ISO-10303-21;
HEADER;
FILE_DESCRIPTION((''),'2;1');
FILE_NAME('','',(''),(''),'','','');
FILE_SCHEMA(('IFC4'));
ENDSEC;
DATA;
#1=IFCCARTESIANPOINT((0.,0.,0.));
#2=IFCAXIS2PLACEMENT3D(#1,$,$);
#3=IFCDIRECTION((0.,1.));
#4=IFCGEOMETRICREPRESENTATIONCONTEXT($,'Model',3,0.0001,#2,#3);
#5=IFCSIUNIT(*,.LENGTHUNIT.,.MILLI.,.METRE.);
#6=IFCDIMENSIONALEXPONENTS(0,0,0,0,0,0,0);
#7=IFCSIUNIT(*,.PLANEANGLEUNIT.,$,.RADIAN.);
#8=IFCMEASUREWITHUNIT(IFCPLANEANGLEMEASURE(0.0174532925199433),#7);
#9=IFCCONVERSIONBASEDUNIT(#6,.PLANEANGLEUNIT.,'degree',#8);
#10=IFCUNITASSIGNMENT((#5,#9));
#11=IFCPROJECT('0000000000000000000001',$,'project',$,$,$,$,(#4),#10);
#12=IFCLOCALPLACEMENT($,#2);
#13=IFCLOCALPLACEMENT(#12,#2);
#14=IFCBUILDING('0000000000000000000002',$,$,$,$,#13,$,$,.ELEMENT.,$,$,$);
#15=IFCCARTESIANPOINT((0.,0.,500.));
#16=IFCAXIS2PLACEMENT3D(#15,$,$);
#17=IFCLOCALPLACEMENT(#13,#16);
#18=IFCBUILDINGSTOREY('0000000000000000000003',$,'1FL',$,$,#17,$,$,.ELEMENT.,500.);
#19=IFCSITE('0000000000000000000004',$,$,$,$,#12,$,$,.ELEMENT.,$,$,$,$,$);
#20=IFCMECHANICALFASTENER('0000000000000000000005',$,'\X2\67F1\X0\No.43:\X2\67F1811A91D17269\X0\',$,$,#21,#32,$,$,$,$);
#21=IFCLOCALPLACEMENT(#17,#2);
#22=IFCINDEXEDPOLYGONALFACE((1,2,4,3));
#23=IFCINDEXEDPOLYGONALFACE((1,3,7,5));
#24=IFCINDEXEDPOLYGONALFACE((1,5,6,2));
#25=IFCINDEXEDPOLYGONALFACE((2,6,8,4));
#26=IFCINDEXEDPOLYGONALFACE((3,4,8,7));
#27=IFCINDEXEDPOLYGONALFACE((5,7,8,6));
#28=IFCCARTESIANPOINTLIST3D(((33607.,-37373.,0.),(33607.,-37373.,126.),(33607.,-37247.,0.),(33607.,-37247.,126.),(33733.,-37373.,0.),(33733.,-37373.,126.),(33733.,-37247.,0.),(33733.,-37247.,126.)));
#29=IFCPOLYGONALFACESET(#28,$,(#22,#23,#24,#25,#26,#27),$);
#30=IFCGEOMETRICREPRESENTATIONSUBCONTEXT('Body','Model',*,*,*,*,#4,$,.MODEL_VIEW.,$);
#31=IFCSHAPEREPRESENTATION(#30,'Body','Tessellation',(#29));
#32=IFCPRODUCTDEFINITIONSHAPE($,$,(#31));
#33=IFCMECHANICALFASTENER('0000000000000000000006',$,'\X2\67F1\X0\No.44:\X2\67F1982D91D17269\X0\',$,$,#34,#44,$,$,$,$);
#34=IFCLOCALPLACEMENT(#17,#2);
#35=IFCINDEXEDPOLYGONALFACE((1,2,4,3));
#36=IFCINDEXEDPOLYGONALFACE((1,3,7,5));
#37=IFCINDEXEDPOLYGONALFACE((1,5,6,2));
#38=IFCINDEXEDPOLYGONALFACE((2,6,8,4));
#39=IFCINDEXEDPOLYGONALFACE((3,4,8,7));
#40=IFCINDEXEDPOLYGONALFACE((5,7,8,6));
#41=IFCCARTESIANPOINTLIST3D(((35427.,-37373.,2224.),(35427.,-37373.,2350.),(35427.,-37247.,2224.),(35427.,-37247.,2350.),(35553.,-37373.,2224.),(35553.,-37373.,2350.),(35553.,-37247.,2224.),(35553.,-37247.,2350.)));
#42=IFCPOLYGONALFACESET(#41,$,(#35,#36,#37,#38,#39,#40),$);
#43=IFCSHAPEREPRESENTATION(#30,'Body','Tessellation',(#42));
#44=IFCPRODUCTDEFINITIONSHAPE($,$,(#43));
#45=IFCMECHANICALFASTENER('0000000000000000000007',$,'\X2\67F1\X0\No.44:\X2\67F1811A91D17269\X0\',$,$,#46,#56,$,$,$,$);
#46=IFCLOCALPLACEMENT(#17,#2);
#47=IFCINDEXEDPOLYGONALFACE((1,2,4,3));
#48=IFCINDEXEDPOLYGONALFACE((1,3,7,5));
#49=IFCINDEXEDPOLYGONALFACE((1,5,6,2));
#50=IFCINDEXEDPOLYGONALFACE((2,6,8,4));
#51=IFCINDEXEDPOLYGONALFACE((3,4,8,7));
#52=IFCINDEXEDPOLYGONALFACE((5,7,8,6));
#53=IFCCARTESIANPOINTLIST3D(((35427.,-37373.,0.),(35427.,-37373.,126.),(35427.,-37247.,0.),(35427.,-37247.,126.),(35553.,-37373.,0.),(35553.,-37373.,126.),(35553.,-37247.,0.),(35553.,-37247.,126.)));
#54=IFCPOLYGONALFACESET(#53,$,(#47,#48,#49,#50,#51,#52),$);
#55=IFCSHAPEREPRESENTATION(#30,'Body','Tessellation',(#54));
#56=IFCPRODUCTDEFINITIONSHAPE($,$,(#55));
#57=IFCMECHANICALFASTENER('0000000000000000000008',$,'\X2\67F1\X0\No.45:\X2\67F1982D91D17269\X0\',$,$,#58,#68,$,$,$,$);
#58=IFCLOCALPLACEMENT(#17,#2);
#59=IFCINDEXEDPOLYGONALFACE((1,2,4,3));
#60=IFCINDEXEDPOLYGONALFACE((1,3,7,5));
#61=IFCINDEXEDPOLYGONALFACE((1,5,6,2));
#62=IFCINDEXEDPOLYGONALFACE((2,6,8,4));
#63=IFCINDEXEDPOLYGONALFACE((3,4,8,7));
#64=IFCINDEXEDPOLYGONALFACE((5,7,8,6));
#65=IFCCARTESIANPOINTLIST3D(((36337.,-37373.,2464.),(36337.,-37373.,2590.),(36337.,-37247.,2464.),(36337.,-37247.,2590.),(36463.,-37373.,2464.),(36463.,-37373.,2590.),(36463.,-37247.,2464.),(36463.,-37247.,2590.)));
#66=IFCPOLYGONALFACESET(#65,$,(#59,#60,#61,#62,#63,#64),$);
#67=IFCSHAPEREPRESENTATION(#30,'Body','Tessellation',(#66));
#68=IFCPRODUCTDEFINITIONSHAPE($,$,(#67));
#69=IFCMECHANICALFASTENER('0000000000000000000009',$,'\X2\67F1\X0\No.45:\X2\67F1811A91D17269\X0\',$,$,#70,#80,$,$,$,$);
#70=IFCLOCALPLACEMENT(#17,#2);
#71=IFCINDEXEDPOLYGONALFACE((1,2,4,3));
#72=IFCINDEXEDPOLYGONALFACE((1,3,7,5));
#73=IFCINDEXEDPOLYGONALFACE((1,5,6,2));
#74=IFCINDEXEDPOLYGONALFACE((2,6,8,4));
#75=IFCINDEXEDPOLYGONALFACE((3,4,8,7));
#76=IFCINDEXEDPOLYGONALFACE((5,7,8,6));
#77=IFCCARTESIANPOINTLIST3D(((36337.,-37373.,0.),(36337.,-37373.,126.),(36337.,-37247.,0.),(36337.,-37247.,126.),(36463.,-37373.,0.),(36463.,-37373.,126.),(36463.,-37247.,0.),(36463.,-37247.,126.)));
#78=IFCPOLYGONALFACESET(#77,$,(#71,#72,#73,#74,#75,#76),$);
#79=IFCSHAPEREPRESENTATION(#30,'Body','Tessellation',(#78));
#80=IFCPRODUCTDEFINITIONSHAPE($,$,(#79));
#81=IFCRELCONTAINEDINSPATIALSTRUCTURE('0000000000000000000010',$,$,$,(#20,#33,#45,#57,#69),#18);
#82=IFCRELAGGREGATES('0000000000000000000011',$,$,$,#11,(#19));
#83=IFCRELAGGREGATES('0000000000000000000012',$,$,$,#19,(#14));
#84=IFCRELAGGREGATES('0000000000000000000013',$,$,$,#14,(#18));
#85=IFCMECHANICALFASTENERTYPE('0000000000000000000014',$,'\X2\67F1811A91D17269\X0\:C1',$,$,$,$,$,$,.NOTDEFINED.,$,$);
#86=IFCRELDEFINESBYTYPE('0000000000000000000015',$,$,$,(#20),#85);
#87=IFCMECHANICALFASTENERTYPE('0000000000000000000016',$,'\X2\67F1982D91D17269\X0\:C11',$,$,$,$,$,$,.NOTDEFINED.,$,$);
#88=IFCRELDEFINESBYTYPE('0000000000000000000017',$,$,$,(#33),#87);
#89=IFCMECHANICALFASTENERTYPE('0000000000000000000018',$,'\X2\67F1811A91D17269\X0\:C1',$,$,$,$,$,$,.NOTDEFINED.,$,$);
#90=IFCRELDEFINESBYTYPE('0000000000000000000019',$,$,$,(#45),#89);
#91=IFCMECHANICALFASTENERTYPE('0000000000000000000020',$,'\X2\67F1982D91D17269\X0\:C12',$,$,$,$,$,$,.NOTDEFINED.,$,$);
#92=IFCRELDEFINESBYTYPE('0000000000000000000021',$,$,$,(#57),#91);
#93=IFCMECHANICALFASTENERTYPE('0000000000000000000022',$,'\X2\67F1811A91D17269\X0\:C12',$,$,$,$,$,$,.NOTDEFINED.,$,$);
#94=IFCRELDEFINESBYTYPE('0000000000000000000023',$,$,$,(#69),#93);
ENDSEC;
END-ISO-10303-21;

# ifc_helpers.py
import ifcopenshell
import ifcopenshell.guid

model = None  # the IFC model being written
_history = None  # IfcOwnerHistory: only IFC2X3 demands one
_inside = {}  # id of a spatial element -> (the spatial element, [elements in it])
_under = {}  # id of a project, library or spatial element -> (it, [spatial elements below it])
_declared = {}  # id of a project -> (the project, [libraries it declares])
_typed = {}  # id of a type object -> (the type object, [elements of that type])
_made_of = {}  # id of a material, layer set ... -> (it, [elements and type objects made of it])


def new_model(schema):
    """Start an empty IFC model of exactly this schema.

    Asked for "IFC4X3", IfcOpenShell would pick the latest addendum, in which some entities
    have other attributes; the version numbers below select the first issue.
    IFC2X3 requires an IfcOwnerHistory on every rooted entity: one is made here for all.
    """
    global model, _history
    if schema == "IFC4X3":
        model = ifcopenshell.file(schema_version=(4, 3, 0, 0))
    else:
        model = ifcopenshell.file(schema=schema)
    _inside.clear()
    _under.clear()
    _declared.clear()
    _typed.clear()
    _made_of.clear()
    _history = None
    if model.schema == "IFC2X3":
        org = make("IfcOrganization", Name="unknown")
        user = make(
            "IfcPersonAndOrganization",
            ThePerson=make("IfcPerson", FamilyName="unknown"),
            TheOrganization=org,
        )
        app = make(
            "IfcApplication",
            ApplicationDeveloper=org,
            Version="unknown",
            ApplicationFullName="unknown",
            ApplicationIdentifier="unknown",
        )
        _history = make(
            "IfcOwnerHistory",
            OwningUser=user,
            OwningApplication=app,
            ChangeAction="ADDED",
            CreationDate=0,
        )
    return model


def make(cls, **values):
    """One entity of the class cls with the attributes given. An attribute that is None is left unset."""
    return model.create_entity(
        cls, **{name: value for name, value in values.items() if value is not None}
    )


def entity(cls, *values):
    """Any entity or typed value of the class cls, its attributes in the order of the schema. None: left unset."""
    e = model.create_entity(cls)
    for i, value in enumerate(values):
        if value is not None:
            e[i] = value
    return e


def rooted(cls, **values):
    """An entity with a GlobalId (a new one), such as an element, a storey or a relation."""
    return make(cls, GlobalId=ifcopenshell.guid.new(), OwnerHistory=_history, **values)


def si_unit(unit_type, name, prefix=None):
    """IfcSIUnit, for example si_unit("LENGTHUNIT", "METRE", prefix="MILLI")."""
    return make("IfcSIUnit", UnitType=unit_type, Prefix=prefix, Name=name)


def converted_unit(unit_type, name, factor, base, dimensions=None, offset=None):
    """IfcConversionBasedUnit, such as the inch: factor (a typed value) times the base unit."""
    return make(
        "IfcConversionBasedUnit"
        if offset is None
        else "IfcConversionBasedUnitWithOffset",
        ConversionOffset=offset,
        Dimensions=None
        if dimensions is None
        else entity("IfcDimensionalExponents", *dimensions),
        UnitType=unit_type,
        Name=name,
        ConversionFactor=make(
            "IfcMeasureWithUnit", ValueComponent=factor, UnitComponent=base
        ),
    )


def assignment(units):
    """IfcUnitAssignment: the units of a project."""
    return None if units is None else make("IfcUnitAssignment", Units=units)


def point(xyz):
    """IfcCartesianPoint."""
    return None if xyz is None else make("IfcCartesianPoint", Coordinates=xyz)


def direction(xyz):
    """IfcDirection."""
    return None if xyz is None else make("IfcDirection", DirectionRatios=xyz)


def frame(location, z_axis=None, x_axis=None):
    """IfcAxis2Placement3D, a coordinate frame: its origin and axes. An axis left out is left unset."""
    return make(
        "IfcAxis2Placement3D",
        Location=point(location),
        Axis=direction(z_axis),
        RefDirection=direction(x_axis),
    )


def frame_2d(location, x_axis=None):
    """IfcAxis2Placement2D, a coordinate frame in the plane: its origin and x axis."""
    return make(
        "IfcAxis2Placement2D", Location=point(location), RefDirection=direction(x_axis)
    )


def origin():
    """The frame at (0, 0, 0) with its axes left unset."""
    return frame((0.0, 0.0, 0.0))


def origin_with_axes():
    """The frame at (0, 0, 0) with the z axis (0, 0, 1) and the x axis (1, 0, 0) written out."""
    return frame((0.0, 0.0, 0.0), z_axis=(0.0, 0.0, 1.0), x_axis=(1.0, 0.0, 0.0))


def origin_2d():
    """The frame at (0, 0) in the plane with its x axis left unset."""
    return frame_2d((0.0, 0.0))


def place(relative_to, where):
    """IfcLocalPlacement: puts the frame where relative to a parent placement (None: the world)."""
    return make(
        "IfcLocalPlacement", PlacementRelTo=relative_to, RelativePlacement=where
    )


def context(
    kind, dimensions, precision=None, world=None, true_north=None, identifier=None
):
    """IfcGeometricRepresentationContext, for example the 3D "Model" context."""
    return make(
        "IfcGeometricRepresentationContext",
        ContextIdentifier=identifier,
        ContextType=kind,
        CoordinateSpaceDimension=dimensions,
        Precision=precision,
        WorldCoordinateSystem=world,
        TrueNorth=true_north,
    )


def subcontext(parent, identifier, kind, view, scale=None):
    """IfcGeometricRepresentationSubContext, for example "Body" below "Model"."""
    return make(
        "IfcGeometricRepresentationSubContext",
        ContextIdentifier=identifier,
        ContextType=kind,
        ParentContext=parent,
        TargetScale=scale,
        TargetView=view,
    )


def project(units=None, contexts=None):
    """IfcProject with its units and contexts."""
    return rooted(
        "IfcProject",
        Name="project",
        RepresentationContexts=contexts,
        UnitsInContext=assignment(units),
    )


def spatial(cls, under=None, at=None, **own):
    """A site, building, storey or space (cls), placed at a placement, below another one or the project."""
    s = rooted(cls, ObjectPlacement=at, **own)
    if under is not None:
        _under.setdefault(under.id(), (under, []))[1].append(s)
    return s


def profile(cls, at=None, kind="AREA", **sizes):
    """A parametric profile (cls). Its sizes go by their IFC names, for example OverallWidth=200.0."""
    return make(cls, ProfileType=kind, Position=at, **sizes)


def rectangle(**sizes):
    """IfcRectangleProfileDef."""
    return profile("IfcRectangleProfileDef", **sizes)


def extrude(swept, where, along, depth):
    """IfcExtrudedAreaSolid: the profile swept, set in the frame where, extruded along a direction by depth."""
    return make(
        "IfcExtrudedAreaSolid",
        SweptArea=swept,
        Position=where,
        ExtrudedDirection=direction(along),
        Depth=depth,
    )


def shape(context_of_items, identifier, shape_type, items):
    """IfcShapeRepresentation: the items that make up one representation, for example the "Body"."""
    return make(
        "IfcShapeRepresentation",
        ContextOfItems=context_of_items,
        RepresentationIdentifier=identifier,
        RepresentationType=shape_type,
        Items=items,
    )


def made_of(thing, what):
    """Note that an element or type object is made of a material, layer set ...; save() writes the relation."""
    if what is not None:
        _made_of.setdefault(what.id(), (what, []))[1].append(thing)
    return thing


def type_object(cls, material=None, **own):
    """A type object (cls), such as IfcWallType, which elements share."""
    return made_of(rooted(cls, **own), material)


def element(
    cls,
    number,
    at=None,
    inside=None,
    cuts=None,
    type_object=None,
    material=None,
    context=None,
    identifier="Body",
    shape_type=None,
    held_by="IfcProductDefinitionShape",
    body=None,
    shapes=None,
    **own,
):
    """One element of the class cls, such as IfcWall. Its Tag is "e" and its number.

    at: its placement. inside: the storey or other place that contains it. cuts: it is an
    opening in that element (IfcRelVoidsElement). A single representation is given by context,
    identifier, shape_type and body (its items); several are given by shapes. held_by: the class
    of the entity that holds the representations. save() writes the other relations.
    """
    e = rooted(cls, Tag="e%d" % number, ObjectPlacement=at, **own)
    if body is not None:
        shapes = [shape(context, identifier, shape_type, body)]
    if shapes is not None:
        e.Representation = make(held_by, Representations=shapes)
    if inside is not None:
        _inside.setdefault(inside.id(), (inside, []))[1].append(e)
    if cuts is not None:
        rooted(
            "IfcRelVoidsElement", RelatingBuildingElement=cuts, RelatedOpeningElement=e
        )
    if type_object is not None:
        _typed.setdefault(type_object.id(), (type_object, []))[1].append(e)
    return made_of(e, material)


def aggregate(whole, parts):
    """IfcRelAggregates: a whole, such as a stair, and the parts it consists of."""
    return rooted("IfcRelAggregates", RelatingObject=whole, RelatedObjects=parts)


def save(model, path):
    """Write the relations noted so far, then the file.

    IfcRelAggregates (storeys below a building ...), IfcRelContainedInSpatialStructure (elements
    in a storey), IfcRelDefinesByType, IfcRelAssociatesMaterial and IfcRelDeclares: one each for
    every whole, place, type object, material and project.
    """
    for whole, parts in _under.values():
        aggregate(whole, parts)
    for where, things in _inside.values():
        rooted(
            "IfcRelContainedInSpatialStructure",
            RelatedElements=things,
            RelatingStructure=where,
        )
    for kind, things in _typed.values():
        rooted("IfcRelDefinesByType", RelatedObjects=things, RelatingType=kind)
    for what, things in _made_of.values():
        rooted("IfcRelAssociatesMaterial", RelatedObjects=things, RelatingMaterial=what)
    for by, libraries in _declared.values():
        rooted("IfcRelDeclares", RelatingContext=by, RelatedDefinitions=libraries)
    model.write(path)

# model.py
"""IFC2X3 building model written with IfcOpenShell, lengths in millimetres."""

from ifc_helpers import new_model, entity, si_unit, converted_unit, direction, frame, origin, origin_with_axes, origin_2d, place, context, subcontext, project, spatial, rectangle, extrude, type_object, element, save


model = new_model("IFC2X3")

# Units and contexts
model_context = context("Model", 3, precision=0.0001, world=origin(), true_north=direction((0.0, 1.0)))
body_context = subcontext(model_context, "Body", "Model", "MODEL_VIEW")
ifc_project = project(units=[si_unit("LENGTHUNIT", "METRE", prefix="MILLI"), converted_unit("PLANEANGLEUNIT", "degree", entity("IfcPlaneAngleMeasure", 0.0174532925199433), si_unit("PLANEANGLEUNIT", "RADIAN"), dimensions=[0, 0, 0, 0, 0, 0, 0])], contexts=[model_context])

# Site, building, storey
site_placement = place(None, origin())
site = spatial("IfcSite", under=ifc_project, at=site_placement, CompositionType="ELEMENT")
building_placement = place(site_placement, origin())
building = spatial("IfcBuilding", under=site, at=building_placement, CompositionType="ELEMENT")
storey_placement = place(building_placement, frame((0.0, 0.0, 500.0)))
storey = spatial("IfcBuildingStorey", under=building, at=storey_placement, Name="1FL", CompositionType="ELEMENT", Elevation=500.0)

# Mechanical fasteners
mechanical_fastener_type_1 = type_object("IfcMechanicalFastenerType", Name="柱脚金物:C1")
mechanical_fastener_1_placement = place(storey_placement, frame((33670.0, -37310.0, 0.0)))
element("IfcMechanicalFastener", 1, at=mechanical_fastener_1_placement, inside=storey, type_object=mechanical_fastener_type_1, Name="柱No.43:柱脚金物", context=body_context, shape_type="SweptSolid", body=[
    extrude(rectangle(XDim=126.0, YDim=126.0, at=origin_2d()), origin_with_axes(), (0.0, 0.0, 1.0), 126.0),
])
mechanical_fastener_type_2 = type_object("IfcMechanicalFastenerType", Name="柱頭金物:C11")
mechanical_fastener_2_placement = place(storey_placement, frame((35490.0, -37310.0, 2224.0)))
element("IfcMechanicalFastener", 2, at=mechanical_fastener_2_placement, inside=storey, type_object=mechanical_fastener_type_2, Name="柱No.44:柱頭金物", context=body_context, shape_type="SweptSolid", body=[
    extrude(rectangle(XDim=126.0, YDim=126.0, at=origin_2d()), origin_with_axes(), (0.0, 0.0, 1.0), 126.0),
])
mechanical_fastener_type_3 = type_object("IfcMechanicalFastenerType", Name="柱脚金物:C1")
mechanical_fastener_3_placement = place(storey_placement, frame((35490.0, -37310.0, 0.0)))
element("IfcMechanicalFastener", 3, at=mechanical_fastener_3_placement, inside=storey, type_object=mechanical_fastener_type_3, Name="柱No.44:柱脚金物", context=body_context, shape_type="SweptSolid", body=[
    extrude(rectangle(XDim=126.0, YDim=126.0, at=origin_2d()), origin_with_axes(), (0.0, 0.0, 1.0), 126.0),
])
mechanical_fastener_type_4 = type_object("IfcMechanicalFastenerType", Name="柱頭金物:C12")
mechanical_fastener_4_placement = place(storey_placement, frame((36400.0, -37310.0, 2464.0)))
element("IfcMechanicalFastener", 4, at=mechanical_fastener_4_placement, inside=storey, type_object=mechanical_fastener_type_4, Name="柱No.45:柱頭金物", context=body_context, shape_type="SweptSolid", body=[
    extrude(rectangle(XDim=126.0, YDim=126.0, at=origin_2d()), origin_with_axes(), (0.0, 0.0, 1.0), 126.0),
])
mechanical_fastener_type_5 = type_object("IfcMechanicalFastenerType", Name="柱脚金物:C12")
mechanical_fastener_5_placement = place(storey_placement, frame((36400.0, -37310.0, 0.0)))
element("IfcMechanicalFastener", 5, at=mechanical_fastener_5_placement, inside=storey, type_object=mechanical_fastener_type_5, Name="柱No.45:柱脚金物", context=body_context, shape_type="SweptSolid", body=[
    extrude(rectangle(XDim=126.0, YDim=126.0, at=origin_2d()), origin_with_axes(), (0.0, 0.0, 1.0), 126.0),
])

save(model, "model.ifc")
